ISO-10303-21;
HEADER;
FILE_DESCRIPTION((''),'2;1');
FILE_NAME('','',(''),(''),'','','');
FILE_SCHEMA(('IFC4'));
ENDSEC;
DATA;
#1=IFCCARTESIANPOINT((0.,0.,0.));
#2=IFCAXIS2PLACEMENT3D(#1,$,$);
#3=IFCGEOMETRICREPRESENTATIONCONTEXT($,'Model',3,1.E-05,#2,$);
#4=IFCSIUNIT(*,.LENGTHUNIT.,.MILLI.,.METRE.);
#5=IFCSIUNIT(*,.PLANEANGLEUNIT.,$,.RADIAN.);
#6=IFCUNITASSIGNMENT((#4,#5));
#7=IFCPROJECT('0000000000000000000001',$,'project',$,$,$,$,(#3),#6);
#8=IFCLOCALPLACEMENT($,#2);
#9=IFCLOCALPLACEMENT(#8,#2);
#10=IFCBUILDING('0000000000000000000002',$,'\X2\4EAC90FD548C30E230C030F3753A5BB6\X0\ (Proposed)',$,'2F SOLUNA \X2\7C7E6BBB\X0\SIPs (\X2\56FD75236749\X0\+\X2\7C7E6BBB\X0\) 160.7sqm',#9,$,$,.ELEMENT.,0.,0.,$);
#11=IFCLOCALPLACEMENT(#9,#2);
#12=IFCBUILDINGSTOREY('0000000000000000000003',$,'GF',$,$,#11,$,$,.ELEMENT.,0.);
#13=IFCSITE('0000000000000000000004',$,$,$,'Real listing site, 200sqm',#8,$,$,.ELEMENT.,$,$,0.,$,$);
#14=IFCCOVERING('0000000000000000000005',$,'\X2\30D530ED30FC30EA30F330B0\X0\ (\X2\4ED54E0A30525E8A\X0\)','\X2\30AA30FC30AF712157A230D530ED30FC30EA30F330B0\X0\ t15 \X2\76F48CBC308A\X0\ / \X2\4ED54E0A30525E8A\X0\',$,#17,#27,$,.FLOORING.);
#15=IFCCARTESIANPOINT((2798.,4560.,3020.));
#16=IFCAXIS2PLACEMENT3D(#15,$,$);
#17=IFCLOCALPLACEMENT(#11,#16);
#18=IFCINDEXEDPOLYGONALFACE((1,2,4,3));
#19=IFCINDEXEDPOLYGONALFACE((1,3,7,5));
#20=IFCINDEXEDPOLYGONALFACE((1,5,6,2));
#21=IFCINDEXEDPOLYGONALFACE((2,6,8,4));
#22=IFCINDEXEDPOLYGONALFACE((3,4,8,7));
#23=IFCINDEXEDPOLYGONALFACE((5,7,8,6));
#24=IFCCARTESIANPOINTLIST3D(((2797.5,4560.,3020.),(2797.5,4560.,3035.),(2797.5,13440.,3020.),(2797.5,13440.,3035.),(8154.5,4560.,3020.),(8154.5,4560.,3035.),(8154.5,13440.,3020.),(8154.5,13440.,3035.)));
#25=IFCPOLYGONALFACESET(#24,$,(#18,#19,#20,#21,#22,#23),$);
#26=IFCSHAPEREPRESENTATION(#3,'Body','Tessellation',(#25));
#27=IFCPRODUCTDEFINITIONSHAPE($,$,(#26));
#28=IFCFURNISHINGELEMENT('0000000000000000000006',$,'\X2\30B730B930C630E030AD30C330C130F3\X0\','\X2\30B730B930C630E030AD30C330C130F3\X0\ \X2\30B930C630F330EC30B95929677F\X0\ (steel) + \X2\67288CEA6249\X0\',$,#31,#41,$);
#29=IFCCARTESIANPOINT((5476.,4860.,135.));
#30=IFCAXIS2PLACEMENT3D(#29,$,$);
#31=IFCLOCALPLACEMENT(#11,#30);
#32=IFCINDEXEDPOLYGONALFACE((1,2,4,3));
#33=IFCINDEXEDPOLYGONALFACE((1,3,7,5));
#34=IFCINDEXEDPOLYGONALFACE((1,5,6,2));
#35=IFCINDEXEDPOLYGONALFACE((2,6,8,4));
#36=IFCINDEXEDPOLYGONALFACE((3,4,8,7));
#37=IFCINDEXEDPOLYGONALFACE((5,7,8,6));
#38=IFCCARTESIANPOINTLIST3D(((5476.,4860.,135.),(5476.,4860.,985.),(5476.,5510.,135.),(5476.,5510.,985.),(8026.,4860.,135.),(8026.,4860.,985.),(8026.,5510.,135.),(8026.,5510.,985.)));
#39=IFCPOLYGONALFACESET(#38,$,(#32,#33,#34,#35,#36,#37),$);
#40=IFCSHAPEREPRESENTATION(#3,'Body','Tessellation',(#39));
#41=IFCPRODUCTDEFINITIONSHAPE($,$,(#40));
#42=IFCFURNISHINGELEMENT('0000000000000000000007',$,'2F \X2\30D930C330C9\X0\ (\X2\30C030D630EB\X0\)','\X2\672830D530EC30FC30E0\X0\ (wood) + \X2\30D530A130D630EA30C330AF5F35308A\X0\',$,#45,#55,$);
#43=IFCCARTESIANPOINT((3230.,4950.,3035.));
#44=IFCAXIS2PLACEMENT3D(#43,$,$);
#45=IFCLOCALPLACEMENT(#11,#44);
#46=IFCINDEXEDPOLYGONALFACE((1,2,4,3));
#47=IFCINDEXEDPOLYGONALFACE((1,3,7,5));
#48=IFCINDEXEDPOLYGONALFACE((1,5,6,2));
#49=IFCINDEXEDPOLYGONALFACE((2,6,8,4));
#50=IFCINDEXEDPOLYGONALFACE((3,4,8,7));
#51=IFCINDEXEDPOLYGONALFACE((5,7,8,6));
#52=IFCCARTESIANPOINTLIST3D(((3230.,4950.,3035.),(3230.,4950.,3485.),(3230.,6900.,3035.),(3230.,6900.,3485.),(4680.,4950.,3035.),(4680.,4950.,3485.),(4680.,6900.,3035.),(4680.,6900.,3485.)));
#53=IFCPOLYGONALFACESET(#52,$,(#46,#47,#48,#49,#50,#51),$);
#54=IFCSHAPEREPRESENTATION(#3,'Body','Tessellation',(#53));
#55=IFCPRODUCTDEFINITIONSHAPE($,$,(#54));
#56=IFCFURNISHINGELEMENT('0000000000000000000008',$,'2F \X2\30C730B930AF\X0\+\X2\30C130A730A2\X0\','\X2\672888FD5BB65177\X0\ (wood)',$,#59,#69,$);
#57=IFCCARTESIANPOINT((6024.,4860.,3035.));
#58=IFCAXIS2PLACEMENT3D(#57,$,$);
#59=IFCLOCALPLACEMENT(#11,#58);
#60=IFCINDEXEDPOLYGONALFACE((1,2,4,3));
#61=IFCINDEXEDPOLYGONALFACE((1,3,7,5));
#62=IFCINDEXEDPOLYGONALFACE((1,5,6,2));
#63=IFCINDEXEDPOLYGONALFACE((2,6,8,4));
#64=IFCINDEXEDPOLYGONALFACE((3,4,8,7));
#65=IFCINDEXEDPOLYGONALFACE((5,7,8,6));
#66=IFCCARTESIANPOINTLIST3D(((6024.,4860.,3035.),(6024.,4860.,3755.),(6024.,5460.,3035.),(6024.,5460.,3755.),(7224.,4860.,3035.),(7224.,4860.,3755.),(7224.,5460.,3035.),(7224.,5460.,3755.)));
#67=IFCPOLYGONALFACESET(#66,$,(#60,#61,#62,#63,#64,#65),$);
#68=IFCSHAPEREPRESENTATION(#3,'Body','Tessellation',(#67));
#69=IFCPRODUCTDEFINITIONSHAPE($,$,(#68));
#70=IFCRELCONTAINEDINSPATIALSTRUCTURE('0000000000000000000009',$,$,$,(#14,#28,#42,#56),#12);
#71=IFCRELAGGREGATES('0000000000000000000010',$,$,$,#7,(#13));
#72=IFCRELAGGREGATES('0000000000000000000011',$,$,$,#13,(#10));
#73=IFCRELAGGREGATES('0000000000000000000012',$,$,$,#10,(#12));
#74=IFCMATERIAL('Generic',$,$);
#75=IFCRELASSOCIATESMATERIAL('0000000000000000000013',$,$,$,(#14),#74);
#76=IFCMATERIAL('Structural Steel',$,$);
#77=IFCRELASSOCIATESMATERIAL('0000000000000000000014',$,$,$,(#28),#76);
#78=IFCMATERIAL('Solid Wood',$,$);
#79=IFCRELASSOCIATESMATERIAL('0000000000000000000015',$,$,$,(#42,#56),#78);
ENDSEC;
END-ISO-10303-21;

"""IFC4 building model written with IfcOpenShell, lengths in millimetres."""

from ifc_helpers import new_model, si_unit, frame, frame_2d, origin, place, context, project, spatial, rectangle, extrude, material, element, save


model = new_model("IFC4")

# Units and contexts
model_context = context("Model", 3, precision=1e-05, world=origin())
ifc_project = project(units=[si_unit("LENGTHUNIT", "METRE", prefix="MILLI"), si_unit("PLANEANGLEUNIT", "RADIAN")], contexts=[model_context])

# Site, building, storey
site_placement = place(None, origin())
site = spatial("IfcSite", under=ifc_project, at=site_placement, ObjectType="Real listing site, 200sqm", CompositionType="ELEMENT", RefElevation=0.0)
building_placement = place(site_placement, origin())
building = spatial("IfcBuilding", under=site, at=building_placement, Name="京都和モダン町家 (Proposed)", ObjectType="2F SOLUNA 籾殻SIPs (国産杉+籾殻) 160.7sqm", CompositionType="ELEMENT", ElevationOfRefHeight=0.0, ElevationOfTerrain=0.0)
storey_placement = place(building_placement, origin())
storey = spatial("IfcBuildingStorey", under=building, at=storey_placement, Name="GF", CompositionType="ELEMENT", Elevation=0.0)

# Shared definitions
ifc_material_1 = material(Name="Solid Wood")

# Shared definitions
ifc_material_2 = material(Name="Generic")

# Shared definitions
ifc_material_3 = material(Name="Structural Steel")

# Covering
covering_placement = place(storey_placement, frame((2798.0, 4560.0, 3020.0)))
element("IfcCovering", 1, at=covering_placement, inside=storey, material=ifc_material_2, Name="フローリング (仕上げ床)", Description="オーク無垢フローリング t15 直貼り / 仕上げ床", PredefinedType="FLOORING", context=model_context, shape_type="SweptSolid", body=[
    extrude(rectangle(XDim=5357.0, YDim=8880.0, at=frame_2d((2678.0, 4440.0))), frame((2798.0, 4560.0, 3020.0)), (0.0, 0.0, 1.0), 15.0),
])

# Furnishing elements
furnishing_1_placement = place(storey_placement, frame((5476.0, 4860.0, 135.0)))
element("IfcFurnishingElement", 2, at=furnishing_1_placement, inside=storey, material=ifc_material_3, Name="システムキッチン", Description="システムキッチン ステンレス天板 (steel) + 木質扉", context=model_context, shape_type="SweptSolid", body=[
    extrude(rectangle(XDim=2550.0, YDim=650.0, at=frame_2d((1275.0, 325.0))), frame((5476.0, 4860.0, 135.0)), (0.0, 0.0, 1.0), 850.0),
])
furnishing_2_placement = place(storey_placement, frame((3230.0, 4950.0, 3035.0)))
element("IfcFurnishingElement", 3, at=furnishing_2_placement, inside=storey, material=ifc_material_1, Name="2F ベッド (ダブル)", Description="木フレーム (wood) + ファブリック張り", context=model_context, shape_type="SweptSolid", body=[
    extrude(rectangle(XDim=1450.0, YDim=1950.0, at=frame_2d((725.0, 975.0))), frame((3230.0, 4950.0, 3035.0)), (0.0, 0.0, 1.0), 450.0),
])
furnishing_3_placement = place(storey_placement, frame((6024.0, 4860.0, 3035.0)))
element("IfcFurnishingElement", 4, at=furnishing_3_placement, inside=storey, material=ifc_material_1, Name="2F デスク+チェア", Description="木製家具 (wood)", context=model_context, shape_type="SweptSolid", body=[
    extrude(rectangle(XDim=1200.0, YDim=600.0, at=frame_2d((600.0, 300.0))), frame((6024.0, 4860.0, 3035.0)), (0.0, 0.0, 1.0), 720.0),
])

save(model, "model.ifc")
